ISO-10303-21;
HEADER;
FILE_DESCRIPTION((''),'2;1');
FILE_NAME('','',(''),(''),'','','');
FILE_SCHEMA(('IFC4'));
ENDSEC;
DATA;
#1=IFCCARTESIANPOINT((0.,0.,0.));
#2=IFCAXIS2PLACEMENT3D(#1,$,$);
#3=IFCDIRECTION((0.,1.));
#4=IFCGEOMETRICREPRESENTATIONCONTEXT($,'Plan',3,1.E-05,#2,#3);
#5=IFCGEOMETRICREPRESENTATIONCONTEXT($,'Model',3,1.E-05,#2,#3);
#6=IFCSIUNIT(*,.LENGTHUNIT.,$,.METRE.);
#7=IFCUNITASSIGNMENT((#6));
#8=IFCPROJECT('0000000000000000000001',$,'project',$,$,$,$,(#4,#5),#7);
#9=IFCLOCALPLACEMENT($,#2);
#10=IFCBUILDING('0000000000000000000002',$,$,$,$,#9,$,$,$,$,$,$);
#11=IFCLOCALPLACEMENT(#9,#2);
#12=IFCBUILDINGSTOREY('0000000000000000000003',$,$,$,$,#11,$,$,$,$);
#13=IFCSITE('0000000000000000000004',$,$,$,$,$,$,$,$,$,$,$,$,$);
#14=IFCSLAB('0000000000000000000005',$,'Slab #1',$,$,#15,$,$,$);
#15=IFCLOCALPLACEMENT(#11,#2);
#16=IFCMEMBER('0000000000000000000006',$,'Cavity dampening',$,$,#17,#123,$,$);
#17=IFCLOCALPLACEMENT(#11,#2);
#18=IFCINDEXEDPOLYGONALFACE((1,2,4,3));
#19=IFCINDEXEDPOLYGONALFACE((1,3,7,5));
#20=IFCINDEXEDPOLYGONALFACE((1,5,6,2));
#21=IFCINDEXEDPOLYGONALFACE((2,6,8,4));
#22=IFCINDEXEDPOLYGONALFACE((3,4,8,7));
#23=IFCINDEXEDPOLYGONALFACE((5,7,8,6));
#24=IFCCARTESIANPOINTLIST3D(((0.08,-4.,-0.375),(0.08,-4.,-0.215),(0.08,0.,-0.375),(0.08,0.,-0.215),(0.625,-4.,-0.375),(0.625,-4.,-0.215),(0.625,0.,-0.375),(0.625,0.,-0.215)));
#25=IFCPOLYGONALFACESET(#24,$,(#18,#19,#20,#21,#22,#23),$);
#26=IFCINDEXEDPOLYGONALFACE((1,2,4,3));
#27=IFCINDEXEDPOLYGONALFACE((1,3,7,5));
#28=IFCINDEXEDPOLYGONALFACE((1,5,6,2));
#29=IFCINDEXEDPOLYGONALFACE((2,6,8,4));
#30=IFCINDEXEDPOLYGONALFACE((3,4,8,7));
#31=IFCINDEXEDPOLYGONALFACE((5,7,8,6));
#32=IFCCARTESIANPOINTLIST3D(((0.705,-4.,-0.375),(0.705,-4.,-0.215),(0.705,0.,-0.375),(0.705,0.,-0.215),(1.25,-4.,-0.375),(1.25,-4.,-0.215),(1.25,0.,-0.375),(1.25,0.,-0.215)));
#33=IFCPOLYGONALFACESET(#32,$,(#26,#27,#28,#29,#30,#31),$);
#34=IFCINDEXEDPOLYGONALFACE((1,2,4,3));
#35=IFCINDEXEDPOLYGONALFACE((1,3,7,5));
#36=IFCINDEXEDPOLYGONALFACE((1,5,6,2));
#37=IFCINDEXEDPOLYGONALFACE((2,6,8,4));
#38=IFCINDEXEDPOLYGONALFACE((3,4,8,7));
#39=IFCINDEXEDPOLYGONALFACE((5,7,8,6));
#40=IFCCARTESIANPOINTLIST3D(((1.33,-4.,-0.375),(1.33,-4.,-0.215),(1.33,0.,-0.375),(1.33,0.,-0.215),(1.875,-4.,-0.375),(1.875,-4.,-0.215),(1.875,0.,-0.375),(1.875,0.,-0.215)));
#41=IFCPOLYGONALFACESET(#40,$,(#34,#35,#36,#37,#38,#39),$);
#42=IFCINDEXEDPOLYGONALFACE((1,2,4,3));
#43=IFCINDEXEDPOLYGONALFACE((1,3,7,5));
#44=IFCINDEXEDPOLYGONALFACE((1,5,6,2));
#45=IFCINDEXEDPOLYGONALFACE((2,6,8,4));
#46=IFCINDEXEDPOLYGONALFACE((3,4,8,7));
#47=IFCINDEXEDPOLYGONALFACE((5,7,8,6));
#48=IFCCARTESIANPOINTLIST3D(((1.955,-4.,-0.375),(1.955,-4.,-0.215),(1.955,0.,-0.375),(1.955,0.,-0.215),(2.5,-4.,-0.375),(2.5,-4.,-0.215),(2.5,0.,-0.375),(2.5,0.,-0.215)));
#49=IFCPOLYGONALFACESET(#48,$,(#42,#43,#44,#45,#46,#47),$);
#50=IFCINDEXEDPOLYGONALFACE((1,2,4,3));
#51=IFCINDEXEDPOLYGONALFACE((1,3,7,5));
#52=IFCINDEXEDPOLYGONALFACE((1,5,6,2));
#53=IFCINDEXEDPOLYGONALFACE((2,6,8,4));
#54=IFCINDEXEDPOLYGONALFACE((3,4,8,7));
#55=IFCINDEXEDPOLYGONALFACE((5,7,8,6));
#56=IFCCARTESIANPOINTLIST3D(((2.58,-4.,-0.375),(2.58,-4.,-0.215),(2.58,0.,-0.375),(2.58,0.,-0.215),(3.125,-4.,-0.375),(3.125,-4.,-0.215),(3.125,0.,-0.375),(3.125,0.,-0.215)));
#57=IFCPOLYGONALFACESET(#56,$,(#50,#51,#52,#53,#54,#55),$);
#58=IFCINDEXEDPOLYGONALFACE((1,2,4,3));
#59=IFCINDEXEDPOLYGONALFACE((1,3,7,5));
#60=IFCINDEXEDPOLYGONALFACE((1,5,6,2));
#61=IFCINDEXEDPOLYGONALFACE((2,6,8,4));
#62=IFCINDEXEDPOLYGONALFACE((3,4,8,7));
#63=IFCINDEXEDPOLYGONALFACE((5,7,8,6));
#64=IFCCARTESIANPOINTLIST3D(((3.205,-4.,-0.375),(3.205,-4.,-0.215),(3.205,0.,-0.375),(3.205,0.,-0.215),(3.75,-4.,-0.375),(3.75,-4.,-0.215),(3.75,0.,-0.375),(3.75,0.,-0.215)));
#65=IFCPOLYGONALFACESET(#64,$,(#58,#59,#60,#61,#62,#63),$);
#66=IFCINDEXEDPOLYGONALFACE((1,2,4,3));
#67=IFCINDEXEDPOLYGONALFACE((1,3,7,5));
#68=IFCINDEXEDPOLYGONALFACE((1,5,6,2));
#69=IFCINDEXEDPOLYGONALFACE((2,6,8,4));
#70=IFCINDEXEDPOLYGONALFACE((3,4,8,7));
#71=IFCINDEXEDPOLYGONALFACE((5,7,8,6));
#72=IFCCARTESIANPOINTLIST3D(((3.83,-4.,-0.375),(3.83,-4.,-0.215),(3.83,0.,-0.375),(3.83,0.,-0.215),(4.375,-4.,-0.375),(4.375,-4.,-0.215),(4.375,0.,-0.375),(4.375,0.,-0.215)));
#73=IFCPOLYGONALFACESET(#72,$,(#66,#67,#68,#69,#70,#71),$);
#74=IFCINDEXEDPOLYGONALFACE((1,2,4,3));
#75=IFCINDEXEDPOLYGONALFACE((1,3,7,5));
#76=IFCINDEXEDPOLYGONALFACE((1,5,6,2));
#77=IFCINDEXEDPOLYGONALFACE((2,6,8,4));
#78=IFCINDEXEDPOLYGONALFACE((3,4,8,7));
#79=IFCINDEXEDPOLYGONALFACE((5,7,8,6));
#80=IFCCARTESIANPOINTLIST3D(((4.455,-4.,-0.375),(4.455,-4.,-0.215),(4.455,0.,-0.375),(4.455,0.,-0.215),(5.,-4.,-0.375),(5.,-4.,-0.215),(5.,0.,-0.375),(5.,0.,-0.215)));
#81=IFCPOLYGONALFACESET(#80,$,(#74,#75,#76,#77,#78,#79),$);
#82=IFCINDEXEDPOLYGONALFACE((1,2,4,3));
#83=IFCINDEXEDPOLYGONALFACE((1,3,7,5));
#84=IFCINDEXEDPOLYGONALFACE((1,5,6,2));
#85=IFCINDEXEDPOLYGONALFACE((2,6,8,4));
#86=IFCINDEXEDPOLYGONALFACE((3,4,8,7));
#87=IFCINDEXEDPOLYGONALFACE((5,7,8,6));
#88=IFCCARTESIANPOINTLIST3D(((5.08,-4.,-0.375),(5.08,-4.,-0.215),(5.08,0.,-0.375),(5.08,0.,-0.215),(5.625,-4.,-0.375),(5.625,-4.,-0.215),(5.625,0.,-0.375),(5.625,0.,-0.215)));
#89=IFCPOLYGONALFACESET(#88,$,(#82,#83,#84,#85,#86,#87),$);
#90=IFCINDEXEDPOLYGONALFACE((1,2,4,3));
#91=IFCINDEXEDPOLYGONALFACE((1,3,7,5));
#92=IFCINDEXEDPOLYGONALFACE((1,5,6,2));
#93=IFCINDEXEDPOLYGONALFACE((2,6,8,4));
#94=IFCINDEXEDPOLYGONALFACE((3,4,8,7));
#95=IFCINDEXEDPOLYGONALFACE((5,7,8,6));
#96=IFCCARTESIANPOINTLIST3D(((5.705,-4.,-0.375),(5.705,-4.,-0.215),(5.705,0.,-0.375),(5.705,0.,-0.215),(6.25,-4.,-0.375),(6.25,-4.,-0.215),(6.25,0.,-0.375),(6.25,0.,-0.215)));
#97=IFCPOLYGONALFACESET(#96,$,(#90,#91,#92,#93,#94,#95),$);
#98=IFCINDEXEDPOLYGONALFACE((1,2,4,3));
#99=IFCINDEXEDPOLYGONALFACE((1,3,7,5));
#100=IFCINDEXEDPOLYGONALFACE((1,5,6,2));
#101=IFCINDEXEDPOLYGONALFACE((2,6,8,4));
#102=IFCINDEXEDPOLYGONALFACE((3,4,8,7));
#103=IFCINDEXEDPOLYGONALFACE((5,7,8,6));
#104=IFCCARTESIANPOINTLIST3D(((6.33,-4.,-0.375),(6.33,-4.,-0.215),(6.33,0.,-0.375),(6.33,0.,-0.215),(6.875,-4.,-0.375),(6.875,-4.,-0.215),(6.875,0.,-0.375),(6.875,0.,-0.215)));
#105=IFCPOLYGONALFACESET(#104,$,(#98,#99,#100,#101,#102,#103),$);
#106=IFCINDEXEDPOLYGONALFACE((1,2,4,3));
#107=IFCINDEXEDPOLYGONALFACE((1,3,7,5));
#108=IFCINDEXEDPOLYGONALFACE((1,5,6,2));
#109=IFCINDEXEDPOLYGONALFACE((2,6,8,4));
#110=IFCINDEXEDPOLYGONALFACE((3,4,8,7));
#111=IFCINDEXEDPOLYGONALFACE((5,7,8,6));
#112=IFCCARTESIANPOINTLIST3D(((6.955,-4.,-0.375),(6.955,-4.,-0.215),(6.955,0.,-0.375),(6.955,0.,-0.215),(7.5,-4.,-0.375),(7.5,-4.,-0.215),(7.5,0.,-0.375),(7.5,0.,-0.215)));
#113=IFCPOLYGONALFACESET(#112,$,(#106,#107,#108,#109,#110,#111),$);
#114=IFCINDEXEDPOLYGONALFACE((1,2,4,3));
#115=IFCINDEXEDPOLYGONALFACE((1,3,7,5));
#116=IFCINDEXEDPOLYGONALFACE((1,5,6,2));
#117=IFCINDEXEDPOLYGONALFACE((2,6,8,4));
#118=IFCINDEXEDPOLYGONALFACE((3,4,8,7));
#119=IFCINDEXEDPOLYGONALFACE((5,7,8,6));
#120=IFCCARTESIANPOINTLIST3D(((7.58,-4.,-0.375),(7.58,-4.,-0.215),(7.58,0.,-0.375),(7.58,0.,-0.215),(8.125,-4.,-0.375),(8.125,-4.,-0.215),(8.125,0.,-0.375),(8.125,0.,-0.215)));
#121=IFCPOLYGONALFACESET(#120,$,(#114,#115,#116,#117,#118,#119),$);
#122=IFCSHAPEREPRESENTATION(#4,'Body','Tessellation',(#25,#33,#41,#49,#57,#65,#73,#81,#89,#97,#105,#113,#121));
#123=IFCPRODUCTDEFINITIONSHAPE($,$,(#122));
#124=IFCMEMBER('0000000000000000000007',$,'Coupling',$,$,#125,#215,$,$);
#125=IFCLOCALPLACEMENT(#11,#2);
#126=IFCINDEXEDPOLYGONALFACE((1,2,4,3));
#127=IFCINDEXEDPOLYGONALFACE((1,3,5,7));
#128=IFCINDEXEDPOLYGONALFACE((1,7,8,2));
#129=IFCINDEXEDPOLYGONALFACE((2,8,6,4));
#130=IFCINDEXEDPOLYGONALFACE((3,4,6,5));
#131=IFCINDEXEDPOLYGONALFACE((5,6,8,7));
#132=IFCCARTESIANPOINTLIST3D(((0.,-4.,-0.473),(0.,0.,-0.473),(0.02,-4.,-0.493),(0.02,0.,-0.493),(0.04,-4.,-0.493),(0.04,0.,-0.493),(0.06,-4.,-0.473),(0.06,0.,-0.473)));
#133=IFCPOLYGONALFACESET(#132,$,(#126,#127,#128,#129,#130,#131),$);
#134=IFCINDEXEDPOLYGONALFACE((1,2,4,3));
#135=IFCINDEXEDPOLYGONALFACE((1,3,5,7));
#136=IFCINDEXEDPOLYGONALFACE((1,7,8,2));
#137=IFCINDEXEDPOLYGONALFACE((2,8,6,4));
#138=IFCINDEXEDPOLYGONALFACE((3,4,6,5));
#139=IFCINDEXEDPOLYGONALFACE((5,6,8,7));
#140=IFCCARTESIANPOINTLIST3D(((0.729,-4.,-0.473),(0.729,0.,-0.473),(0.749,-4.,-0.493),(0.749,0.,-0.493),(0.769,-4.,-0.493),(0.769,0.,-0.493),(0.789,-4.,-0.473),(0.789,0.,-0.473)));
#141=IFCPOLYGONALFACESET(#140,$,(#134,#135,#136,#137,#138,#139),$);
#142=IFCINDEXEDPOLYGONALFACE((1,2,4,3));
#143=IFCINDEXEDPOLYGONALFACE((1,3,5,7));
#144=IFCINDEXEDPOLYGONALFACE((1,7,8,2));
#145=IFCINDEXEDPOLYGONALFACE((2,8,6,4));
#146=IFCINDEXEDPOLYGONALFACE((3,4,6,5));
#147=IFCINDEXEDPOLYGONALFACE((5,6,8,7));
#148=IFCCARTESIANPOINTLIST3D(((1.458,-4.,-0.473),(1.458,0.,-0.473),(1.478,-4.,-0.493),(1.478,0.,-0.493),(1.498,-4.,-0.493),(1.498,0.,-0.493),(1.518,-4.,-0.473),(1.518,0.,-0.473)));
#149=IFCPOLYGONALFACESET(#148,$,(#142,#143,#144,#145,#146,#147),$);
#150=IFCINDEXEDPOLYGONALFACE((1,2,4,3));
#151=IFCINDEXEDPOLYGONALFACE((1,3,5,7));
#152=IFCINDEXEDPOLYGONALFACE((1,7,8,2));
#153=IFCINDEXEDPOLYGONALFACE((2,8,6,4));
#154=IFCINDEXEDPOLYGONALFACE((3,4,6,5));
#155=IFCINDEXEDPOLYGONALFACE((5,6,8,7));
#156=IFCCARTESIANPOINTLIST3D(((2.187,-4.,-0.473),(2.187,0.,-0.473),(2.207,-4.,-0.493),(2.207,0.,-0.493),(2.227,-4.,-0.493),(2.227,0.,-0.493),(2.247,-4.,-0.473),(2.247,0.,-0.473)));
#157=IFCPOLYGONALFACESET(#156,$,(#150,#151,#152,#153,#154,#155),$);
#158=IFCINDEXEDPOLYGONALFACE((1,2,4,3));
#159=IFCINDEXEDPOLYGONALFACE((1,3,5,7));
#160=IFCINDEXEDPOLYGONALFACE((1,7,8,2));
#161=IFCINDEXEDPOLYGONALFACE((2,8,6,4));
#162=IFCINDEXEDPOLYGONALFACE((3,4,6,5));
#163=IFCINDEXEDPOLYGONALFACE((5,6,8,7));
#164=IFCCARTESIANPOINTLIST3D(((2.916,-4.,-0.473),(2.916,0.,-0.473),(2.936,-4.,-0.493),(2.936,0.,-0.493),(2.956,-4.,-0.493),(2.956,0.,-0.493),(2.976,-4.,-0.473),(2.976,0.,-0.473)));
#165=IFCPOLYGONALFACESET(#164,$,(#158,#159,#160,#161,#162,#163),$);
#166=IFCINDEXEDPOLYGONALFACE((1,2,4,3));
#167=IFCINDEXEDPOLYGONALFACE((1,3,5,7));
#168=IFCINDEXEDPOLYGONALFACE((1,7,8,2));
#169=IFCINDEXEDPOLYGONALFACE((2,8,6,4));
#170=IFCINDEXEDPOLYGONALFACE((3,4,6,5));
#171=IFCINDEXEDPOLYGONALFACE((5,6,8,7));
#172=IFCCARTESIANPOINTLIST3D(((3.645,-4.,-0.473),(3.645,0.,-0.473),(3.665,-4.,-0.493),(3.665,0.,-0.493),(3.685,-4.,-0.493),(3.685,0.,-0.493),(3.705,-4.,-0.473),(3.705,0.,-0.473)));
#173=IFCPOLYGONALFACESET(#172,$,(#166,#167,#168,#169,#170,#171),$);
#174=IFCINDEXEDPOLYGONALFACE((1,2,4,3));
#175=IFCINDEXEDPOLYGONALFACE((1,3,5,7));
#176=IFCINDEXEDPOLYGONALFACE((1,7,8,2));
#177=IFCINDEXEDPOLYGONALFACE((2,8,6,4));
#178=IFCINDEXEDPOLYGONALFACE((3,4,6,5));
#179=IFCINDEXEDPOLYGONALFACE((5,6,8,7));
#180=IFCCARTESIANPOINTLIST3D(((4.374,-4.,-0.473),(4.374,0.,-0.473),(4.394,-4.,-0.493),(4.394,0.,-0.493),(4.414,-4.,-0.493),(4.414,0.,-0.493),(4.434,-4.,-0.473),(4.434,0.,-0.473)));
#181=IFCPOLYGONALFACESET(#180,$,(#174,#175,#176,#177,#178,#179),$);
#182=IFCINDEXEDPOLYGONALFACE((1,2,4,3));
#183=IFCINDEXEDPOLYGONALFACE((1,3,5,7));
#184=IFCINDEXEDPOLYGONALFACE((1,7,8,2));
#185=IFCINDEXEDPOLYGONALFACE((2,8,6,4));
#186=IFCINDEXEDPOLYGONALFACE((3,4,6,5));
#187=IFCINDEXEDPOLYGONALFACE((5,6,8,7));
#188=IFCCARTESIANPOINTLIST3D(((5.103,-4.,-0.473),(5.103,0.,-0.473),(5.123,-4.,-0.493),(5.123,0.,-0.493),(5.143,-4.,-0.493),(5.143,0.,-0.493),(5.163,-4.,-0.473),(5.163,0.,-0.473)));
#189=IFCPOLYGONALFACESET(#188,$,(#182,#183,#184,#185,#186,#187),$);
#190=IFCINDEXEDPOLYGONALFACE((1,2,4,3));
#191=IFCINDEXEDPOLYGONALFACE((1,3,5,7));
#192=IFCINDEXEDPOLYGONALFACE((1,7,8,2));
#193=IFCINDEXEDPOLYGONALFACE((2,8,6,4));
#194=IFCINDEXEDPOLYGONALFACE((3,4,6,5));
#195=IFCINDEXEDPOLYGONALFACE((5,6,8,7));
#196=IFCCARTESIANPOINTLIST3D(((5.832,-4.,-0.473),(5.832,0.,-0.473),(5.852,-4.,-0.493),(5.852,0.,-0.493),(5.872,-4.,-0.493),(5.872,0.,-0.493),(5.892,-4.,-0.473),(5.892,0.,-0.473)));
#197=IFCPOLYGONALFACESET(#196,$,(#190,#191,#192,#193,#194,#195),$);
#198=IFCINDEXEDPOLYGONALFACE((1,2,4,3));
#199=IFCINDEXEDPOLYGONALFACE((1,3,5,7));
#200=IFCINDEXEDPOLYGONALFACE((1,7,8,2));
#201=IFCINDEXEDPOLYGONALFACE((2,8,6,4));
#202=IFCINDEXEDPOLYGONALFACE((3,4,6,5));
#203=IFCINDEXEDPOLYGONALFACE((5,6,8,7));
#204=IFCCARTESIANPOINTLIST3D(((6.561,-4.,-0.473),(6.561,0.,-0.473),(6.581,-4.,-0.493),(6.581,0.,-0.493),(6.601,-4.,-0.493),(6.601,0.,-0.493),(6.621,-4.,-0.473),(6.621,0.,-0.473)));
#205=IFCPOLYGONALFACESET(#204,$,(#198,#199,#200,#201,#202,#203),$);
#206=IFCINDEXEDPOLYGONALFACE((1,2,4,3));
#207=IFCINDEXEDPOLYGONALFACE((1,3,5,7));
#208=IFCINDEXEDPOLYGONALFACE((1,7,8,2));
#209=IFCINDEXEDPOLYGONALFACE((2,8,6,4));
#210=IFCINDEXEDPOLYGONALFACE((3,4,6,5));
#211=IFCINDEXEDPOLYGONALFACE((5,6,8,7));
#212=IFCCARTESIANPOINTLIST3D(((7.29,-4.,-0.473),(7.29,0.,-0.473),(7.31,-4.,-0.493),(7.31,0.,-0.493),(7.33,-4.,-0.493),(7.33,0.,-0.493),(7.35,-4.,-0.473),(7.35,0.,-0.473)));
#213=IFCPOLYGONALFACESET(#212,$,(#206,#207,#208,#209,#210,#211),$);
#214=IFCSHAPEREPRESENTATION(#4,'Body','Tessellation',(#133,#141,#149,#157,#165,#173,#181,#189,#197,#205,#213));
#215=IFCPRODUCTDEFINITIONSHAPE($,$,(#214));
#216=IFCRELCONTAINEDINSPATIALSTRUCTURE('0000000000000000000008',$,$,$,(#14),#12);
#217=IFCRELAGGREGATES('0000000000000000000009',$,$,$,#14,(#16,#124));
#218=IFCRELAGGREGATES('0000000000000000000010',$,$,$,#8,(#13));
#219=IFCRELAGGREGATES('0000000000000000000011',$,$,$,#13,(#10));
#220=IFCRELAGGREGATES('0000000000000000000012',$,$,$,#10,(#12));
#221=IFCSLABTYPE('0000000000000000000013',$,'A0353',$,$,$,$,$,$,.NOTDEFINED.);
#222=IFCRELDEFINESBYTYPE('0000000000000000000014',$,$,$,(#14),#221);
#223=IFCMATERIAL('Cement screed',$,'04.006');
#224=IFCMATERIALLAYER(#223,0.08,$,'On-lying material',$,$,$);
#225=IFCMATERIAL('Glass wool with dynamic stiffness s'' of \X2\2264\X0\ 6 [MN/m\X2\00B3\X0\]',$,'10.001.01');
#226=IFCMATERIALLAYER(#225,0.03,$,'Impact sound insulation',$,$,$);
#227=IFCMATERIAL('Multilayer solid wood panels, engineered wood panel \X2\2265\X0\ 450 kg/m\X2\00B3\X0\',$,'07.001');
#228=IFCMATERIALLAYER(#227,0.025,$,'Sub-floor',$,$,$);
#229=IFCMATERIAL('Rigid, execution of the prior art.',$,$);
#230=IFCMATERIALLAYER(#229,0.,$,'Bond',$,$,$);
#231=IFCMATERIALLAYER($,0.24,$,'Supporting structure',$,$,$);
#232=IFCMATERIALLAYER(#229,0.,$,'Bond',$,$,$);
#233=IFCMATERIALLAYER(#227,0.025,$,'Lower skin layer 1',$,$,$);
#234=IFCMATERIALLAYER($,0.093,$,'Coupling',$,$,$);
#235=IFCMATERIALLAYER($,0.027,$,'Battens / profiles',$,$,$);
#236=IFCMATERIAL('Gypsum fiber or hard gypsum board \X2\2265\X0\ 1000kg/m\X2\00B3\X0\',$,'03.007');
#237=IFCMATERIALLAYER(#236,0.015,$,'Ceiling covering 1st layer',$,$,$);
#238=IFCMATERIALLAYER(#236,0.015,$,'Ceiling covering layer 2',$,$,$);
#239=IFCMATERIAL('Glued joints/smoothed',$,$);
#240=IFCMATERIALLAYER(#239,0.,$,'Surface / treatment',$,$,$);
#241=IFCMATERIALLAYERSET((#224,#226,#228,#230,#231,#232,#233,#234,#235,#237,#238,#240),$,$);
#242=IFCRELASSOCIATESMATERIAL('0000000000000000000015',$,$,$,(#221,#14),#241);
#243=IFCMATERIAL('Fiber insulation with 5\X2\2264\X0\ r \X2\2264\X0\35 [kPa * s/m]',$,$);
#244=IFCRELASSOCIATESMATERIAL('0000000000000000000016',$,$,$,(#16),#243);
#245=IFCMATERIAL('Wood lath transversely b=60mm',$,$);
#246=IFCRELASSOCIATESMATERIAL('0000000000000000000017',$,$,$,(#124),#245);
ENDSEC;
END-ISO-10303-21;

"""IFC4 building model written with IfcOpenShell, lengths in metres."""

from ifc_helpers import new_model, si_unit, direction, frame, frame_2d, origin, place, context, project, spatial, polyline, rectangle, outline, extrude, material, layer, layer_set, type_object, element, aggregate, save


model = new_model("IFC4")

# Units and contexts
plan_context = context("Plan", 3, precision=1e-05, world=origin(), true_north=direction((0.0, 1.0)))
model_context = context("Model", 3, precision=1e-05, world=origin(), true_north=direction((0.0, 1.0)))
ifc_project = project(units=[si_unit("LENGTHUNIT", "METRE")], contexts=[plan_context, model_context])

# Site, building, storey
site = spatial("IfcSite", under=ifc_project)
building_placement = place(None, origin())
building = spatial("IfcBuilding", under=site, at=building_placement)
storey_placement = place(building_placement, origin())
storey = spatial("IfcBuildingStorey", under=building, at=storey_placement)

# Slab, members
ifc_material_1 = material(Name="Cement screed", Category="04.006")
ifc_layer_1 = layer(ifc_material_1, 0.08, Name="On-lying material")
ifc_material_2 = material(Name="Glass wool with dynamic stiffness s' of ≤ 6 [MN/m³]", Category="10.001.01")
ifc_layer_2 = layer(ifc_material_2, 0.03, Name="Impact sound insulation")
ifc_material_3 = material(Name="Multilayer solid wood panels, engineered wood panel ≥ 450 kg/m³", Category="07.001")
ifc_layer_3 = layer(ifc_material_3, 0.025, Name="Sub-floor")
ifc_material_4 = material(Name="Rigid, execution of the prior art.")
ifc_layer_4 = layer(ifc_material_4, 0.0, Name="Bond")
ifc_layer_5 = layer(None, 0.24, Name="Supporting structure")
ifc_layer_6 = layer(ifc_material_4, 0.0, Name="Bond")
ifc_layer_7 = layer(ifc_material_3, 0.025, Name="Lower skin layer 1")
ifc_layer_8 = layer(None, 0.093, Name="Coupling")
ifc_layer_9 = layer(None, 0.027, Name="Battens / profiles")
ifc_material_5 = material(Name="Gypsum fiber or hard gypsum board ≥ 1000kg/m³", Category="03.007")
ifc_layer_10 = layer(ifc_material_5, 0.015, Name="Ceiling covering 1st layer")
ifc_layer_11 = layer(ifc_material_5, 0.015, Name="Ceiling covering layer 2")
ifc_material_6 = material(Name="Glued joints/smoothed")
ifc_layer_12 = layer(ifc_material_6, 0.0, Name="Surface / treatment")
ifc_layer_set = layer_set([ifc_layer_1, ifc_layer_2, ifc_layer_3, ifc_layer_4, ifc_layer_5, ifc_layer_6, ifc_layer_7, ifc_layer_8, ifc_layer_9, ifc_layer_10, ifc_layer_11, ifc_layer_12])
slab_type = type_object("IfcSlabType", Name="A0353", PredefinedType="NOTDEFINED", material=ifc_layer_set)
slab_placement = place(None, frame((0.0, 0.0, 0.0), z_axis=(0.0, 0.0, -1.0), x_axis=(1.0, 0.0, 0.0)))
slab = element("IfcSlab", 1, at=slab_placement, inside=storey, type_object=slab_type, material=ifc_layer_set, Name="Slab #1")
ifc_material_7 = material(Name="Fiber insulation with 5≤ r ≤35 [kPa * s/m]")
member_1_placement = place(slab_placement, origin())
member_1 = element("IfcMember", 2, at=member_1_placement, material=ifc_material_7, Name="Cavity dampening", context=plan_context, shape_type="SweptSolid", body=[
    extrude(rectangle(XDim=0.545, YDim=0.16, at=frame_2d((0.2725, 0.08), x_axis=(1.0, 0.0))), frame((0.08, 4.0, 0.215), z_axis=(0.0, -1.0, 0.0), x_axis=(1.0, 0.0, 0.0)), (0.0, 0.0, 1.0), 4.0),
    extrude(rectangle(XDim=0.545, YDim=0.16, at=frame_2d((0.2725, 0.08), x_axis=(1.0, 0.0))), frame((0.705, 4.0, 0.215), z_axis=(0.0, -1.0, 0.0), x_axis=(1.0, 0.0, 0.0)), (0.0, 0.0, 1.0), 4.0),
    extrude(rectangle(XDim=0.545, YDim=0.16, at=frame_2d((0.2725, 0.08), x_axis=(1.0, 0.0))), frame((1.33, 4.0, 0.215), z_axis=(0.0, -1.0, 0.0), x_axis=(1.0, 0.0, 0.0)), (0.0, 0.0, 1.0), 4.0),
    extrude(rectangle(XDim=0.545, YDim=0.16, at=frame_2d((0.2725, 0.08), x_axis=(1.0, 0.0))), frame((1.955, 4.0, 0.215), z_axis=(0.0, -1.0, 0.0), x_axis=(1.0, 0.0, 0.0)), (0.0, 0.0, 1.0), 4.0),
    extrude(rectangle(XDim=0.545, YDim=0.16, at=frame_2d((0.2725, 0.08), x_axis=(1.0, 0.0))), frame((2.58, 4.0, 0.215), z_axis=(0.0, -1.0, 0.0), x_axis=(1.0, 0.0, 0.0)), (0.0, 0.0, 1.0), 4.0),
    extrude(rectangle(XDim=0.545, YDim=0.16, at=frame_2d((0.2725, 0.08), x_axis=(1.0, 0.0))), frame((3.205, 4.0, 0.215), z_axis=(0.0, -1.0, 0.0), x_axis=(1.0, 0.0, 0.0)), (0.0, 0.0, 1.0), 4.0),
    extrude(rectangle(XDim=0.545, YDim=0.16, at=frame_2d((0.2725, 0.08), x_axis=(1.0, 0.0))), frame((3.83, 4.0, 0.215), z_axis=(0.0, -1.0, 0.0), x_axis=(1.0, 0.0, 0.0)), (0.0, 0.0, 1.0), 4.0),
    extrude(rectangle(XDim=0.545, YDim=0.16, at=frame_2d((0.2725, 0.08), x_axis=(1.0, 0.0))), frame((4.455, 4.0, 0.215), z_axis=(0.0, -1.0, 0.0), x_axis=(1.0, 0.0, 0.0)), (0.0, 0.0, 1.0), 4.0),
    extrude(rectangle(XDim=0.545, YDim=0.16, at=frame_2d((0.2725, 0.08), x_axis=(1.0, 0.0))), frame((5.08, 4.0, 0.215), z_axis=(0.0, -1.0, 0.0), x_axis=(1.0, 0.0, 0.0)), (0.0, 0.0, 1.0), 4.0),
    extrude(rectangle(XDim=0.545, YDim=0.16, at=frame_2d((0.2725, 0.08), x_axis=(1.0, 0.0))), frame((5.705, 4.0, 0.215), z_axis=(0.0, -1.0, 0.0), x_axis=(1.0, 0.0, 0.0)), (0.0, 0.0, 1.0), 4.0),
    extrude(rectangle(XDim=0.545, YDim=0.16, at=frame_2d((0.2725, 0.08), x_axis=(1.0, 0.0))), frame((6.33, 4.0, 0.215), z_axis=(0.0, -1.0, 0.0), x_axis=(1.0, 0.0, 0.0)), (0.0, 0.0, 1.0), 4.0),
    extrude(rectangle(XDim=0.545, YDim=0.16, at=frame_2d((0.2725, 0.08), x_axis=(1.0, 0.0))), frame((6.955, 4.0, 0.215), z_axis=(0.0, -1.0, 0.0), x_axis=(1.0, 0.0, 0.0)), (0.0, 0.0, 1.0), 4.0),
    extrude(rectangle(XDim=0.545, YDim=0.16, at=frame_2d((0.2725, 0.08), x_axis=(1.0, 0.0))), frame((7.58, 4.0, 0.215), z_axis=(0.0, -1.0, 0.0), x_axis=(1.0, 0.0, 0.0)), (0.0, 0.0, 1.0), 4.0),
])
ifc_material_8 = material(Name="Wood lath transversely b=60mm")
member_2_placement = place(slab_placement, origin())
member_2 = element("IfcMember", 3, at=member_2_placement, material=ifc_material_8, Name="Coupling", context=plan_context, shape_type="SweptSolid", body=[
    extrude(outline(polyline([(0.0, 0.0), (0.06, 0.0), (0.04, 0.02), (0.02, 0.02), (0.0, 0.0)])), frame((0.0, 4.0, 0.473), z_axis=(0.0, -1.0, 0.0), x_axis=(1.0, 0.0, 0.0)), (0.0, 0.0, 1.0), 4.0),
    extrude(outline(polyline([(0.0, 0.0), (0.06, 0.0), (0.04, 0.02), (0.02, 0.02), (0.0, 0.0)])), frame((0.729, 4.0, 0.473), z_axis=(0.0, -1.0, 0.0), x_axis=(1.0, 0.0, 0.0)), (0.0, 0.0, 1.0), 4.0),
    extrude(outline(polyline([(0.0, 0.0), (0.06, 0.0), (0.04, 0.02), (0.02, 0.02), (0.0, 0.0)])), frame((1.458, 4.0, 0.473), z_axis=(0.0, -1.0, 0.0), x_axis=(1.0, 0.0, 0.0)), (0.0, 0.0, 1.0), 4.0),
    extrude(outline(polyline([(0.0, 0.0), (0.06, 0.0), (0.04, 0.02), (0.02, 0.02), (0.0, 0.0)])), frame((2.187, 4.0, 0.473), z_axis=(0.0, -1.0, 0.0), x_axis=(1.0, 0.0, 0.0)), (0.0, 0.0, 1.0), 4.0),
    extrude(outline(polyline([(0.0, 0.0), (0.06, 0.0), (0.04, 0.02), (0.02, 0.02), (0.0, 0.0)])), frame((2.916, 4.0, 0.473), z_axis=(0.0, -1.0, 0.0), x_axis=(1.0, 0.0, 0.0)), (0.0, 0.0, 1.0), 4.0),
    extrude(outline(polyline([(0.0, 0.0), (0.06, 0.0), (0.04, 0.02), (0.02, 0.02), (0.0, 0.0)])), frame((3.645, 4.0, 0.473), z_axis=(0.0, -1.0, 0.0), x_axis=(1.0, 0.0, 0.0)), (0.0, 0.0, 1.0), 4.0),
    extrude(outline(polyline([(0.0, 0.0), (0.06, 0.0), (0.04, 0.02), (0.02, 0.02), (0.0, 0.0)])), frame((4.374, 4.0, 0.473), z_axis=(0.0, -1.0, 0.0), x_axis=(1.0, 0.0, 0.0)), (0.0, 0.0, 1.0), 4.0),
    extrude(outline(polyline([(0.0, 0.0), (0.06, 0.0), (0.04, 0.02), (0.02, 0.02), (0.0, 0.0)])), frame((5.103, 4.0, 0.473), z_axis=(0.0, -1.0, 0.0), x_axis=(1.0, 0.0, 0.0)), (0.0, 0.0, 1.0), 4.0),
    extrude(outline(polyline([(0.0, 0.0), (0.06, 0.0), (0.04, 0.02), (0.02, 0.02), (0.0, 0.0)])), frame((5.832, 4.0, 0.473), z_axis=(0.0, -1.0, 0.0), x_axis=(1.0, 0.0, 0.0)), (0.0, 0.0, 1.0), 4.0),
    extrude(outline(polyline([(0.0, 0.0), (0.06, 0.0), (0.04, 0.02), (0.02, 0.02), (0.0, 0.0)])), frame((6.561, 4.0, 0.473), z_axis=(0.0, -1.0, 0.0), x_axis=(1.0, 0.0, 0.0)), (0.0, 0.0, 1.0), 4.0),
    extrude(outline(polyline([(0.0, 0.0), (0.06, 0.0), (0.04, 0.02), (0.02, 0.02), (0.0, 0.0)])), frame((7.29, 4.0, 0.473), z_axis=(0.0, -1.0, 0.0), x_axis=(1.0, 0.0, 0.0)), (0.0, 0.0, 1.0), 4.0),
])
aggregate(slab, [member_1, member_2])

save(model, "model.ifc")
